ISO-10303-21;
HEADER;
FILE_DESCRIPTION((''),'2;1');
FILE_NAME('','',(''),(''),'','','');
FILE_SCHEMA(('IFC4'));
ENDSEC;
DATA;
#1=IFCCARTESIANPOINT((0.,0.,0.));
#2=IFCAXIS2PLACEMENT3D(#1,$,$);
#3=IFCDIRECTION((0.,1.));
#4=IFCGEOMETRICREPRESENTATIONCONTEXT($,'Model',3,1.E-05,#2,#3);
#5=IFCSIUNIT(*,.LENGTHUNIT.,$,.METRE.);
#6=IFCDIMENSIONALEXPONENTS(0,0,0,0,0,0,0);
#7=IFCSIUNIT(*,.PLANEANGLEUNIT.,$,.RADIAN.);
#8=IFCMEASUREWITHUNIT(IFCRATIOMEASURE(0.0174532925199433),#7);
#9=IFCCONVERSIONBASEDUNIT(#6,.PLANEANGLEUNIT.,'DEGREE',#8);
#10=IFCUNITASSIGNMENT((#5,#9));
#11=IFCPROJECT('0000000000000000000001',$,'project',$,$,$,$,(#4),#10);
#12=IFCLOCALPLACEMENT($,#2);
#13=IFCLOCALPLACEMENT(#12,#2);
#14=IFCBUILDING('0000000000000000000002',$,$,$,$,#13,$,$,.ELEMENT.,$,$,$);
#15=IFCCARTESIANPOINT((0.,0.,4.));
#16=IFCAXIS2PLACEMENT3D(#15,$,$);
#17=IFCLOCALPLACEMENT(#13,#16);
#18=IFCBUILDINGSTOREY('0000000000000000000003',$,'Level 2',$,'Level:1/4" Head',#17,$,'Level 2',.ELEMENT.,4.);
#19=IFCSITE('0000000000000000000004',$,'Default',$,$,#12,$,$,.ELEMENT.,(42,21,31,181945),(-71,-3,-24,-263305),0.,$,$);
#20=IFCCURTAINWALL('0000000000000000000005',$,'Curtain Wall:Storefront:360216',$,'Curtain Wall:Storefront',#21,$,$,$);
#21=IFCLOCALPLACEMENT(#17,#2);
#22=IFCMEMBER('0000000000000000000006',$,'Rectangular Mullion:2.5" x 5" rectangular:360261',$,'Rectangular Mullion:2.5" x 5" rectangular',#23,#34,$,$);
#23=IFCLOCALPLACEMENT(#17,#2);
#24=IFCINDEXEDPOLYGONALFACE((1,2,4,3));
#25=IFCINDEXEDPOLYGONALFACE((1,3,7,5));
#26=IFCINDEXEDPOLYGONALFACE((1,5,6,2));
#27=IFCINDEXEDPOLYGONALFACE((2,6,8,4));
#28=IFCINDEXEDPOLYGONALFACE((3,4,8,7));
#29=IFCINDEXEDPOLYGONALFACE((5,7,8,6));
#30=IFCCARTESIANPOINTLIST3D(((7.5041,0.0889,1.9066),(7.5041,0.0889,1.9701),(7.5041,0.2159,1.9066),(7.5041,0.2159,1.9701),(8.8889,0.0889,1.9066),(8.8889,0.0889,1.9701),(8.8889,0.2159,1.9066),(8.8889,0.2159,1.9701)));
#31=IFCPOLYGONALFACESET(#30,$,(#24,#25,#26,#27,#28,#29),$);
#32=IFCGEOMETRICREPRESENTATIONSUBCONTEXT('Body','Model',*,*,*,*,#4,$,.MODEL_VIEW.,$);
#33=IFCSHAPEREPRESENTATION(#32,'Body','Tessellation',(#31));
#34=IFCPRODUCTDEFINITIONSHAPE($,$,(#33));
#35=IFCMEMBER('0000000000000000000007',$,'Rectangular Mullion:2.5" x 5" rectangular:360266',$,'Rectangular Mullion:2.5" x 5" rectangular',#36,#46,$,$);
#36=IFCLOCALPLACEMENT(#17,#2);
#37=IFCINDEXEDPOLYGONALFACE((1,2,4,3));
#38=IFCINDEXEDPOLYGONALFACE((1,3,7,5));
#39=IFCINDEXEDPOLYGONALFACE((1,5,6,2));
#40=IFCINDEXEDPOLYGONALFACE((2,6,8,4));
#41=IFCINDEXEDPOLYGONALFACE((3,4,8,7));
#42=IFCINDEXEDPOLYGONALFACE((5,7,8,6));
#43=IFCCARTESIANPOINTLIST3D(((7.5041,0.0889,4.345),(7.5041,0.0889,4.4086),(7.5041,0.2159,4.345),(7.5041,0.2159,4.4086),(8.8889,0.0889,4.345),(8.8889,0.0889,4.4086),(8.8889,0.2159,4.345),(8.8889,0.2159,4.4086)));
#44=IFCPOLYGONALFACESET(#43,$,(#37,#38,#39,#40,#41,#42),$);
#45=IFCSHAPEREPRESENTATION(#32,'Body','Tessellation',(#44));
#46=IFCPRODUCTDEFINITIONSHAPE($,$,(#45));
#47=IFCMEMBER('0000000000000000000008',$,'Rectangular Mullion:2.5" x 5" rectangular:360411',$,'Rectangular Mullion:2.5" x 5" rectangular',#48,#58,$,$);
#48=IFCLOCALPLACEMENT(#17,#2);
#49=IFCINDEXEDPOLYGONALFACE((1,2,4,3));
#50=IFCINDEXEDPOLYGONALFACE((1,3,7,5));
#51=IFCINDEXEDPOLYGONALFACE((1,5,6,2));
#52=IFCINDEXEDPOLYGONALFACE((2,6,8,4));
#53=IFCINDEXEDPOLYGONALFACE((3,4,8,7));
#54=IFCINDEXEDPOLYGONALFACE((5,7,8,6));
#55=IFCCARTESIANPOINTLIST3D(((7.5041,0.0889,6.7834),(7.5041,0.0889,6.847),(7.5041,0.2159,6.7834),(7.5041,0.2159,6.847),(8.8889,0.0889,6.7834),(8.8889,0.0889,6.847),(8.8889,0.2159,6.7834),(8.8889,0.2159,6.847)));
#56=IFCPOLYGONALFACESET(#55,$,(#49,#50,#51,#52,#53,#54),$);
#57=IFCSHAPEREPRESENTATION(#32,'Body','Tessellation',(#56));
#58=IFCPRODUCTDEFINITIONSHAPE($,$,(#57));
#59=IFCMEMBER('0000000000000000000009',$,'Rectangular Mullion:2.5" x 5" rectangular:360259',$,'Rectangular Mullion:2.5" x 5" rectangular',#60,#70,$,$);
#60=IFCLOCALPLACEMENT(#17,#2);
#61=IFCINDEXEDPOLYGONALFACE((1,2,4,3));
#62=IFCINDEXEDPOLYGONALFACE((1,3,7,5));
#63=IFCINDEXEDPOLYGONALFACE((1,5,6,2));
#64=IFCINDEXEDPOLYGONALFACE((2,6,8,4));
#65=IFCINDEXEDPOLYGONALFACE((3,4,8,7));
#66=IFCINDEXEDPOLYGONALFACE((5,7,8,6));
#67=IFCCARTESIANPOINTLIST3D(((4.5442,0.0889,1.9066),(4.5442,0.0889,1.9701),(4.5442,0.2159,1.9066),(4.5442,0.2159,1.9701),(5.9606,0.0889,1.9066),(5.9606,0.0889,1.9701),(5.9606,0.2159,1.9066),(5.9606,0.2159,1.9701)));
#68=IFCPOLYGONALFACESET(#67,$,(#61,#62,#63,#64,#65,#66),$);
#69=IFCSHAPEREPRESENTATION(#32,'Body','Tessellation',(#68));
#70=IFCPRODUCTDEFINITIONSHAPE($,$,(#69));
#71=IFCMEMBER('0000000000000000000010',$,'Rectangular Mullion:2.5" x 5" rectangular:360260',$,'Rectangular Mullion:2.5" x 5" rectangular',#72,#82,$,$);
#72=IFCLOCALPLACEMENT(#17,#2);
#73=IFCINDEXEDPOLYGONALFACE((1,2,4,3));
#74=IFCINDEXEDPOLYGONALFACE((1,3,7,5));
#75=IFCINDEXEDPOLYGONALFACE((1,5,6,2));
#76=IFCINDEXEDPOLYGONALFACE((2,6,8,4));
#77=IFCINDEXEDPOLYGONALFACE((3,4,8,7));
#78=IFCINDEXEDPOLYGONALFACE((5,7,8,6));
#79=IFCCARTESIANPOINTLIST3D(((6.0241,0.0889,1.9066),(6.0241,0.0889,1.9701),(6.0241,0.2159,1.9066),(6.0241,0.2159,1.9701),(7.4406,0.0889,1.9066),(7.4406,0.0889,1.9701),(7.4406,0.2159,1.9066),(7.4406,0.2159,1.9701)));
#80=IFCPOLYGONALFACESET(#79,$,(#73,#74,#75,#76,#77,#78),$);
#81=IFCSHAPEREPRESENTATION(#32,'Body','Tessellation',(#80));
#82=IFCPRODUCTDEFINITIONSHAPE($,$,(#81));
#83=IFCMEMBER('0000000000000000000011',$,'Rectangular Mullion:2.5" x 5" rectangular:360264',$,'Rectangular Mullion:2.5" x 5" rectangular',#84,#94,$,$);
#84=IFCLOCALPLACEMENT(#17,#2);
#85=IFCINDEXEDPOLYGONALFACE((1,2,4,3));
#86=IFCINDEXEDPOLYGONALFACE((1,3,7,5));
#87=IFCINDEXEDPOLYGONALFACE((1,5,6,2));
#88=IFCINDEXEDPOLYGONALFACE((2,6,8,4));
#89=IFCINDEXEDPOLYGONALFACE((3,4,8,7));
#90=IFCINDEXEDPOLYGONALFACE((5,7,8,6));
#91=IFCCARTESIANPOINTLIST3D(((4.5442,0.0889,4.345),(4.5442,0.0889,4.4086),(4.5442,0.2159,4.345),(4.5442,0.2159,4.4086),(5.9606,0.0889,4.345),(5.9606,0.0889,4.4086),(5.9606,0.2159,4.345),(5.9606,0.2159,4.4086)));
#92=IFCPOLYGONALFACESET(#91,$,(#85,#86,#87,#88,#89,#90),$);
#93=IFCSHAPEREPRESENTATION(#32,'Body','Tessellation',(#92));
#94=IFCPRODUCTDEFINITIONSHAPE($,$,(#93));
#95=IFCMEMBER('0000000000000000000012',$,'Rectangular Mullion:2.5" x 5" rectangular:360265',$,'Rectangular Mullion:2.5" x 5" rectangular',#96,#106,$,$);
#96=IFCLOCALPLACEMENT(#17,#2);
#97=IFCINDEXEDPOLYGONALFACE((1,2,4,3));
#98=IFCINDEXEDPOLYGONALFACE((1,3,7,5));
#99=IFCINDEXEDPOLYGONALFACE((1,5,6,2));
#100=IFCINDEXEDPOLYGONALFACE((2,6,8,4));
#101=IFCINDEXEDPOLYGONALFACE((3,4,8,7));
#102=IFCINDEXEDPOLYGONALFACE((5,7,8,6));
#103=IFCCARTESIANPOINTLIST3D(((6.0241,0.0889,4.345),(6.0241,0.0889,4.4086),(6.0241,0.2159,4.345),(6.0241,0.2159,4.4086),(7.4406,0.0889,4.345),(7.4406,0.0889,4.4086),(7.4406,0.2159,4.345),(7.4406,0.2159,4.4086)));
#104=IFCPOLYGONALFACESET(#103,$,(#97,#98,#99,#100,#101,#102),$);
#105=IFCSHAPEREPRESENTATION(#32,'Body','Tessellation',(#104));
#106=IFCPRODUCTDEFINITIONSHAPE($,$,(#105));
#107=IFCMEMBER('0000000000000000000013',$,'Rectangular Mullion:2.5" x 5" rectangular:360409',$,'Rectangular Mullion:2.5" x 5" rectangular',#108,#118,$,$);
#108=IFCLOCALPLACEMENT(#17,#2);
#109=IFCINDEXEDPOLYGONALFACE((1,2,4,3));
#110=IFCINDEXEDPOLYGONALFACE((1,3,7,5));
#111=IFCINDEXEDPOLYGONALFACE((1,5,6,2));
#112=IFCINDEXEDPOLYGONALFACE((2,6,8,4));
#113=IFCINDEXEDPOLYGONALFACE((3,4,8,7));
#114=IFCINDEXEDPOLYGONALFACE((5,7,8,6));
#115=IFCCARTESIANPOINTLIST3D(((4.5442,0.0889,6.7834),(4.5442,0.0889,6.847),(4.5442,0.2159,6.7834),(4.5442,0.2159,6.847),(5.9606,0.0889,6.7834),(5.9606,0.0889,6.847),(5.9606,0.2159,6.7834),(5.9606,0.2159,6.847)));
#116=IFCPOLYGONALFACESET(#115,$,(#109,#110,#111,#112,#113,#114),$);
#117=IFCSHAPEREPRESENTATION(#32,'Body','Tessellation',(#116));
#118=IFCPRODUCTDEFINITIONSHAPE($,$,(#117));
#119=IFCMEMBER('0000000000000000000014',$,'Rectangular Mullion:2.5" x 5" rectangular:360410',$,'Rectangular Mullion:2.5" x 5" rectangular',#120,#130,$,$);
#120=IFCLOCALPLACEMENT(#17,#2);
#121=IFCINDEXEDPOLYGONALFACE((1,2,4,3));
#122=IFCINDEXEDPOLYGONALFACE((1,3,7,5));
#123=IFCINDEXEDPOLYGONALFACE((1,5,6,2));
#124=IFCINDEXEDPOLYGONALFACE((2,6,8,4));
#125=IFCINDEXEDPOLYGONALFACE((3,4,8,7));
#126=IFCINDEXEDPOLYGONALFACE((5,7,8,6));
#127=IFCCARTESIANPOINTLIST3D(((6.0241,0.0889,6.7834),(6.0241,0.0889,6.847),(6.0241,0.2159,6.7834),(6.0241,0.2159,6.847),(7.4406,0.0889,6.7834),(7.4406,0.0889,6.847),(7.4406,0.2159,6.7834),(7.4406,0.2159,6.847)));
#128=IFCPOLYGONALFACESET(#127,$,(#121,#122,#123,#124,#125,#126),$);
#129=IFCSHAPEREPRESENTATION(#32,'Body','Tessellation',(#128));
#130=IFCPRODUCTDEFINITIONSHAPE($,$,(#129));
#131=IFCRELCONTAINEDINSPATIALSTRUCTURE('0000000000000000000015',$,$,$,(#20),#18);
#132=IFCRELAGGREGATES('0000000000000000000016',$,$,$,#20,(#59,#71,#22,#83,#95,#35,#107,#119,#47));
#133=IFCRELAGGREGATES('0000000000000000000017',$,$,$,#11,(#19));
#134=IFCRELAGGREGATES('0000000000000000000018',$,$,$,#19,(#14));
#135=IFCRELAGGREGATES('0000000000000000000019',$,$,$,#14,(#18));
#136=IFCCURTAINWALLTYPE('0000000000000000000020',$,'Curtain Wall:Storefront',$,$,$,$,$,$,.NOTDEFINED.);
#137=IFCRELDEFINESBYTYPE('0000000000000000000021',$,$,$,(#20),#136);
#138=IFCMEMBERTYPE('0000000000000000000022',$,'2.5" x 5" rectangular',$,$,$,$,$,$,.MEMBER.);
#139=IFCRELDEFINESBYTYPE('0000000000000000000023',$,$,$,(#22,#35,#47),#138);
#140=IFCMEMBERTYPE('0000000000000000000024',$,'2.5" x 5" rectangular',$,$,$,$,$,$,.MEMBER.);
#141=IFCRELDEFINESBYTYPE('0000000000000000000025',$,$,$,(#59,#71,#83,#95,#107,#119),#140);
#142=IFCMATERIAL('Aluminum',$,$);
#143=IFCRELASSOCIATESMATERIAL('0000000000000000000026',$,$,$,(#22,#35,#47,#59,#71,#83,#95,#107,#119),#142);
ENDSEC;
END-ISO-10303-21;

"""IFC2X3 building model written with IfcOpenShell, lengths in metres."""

from ifc_helpers import new_model, entity, si_unit, converted_unit, direction, frame, origin, origin_2d_with_axis, place, context, subcontext, project, spatial, rectangle, extrude, source, transform, mapped, material, type_object, type_shapes, element, aggregate, save


model = new_model("IFC2X3")

# Units and contexts
model_context = context("Model", 3, precision=1e-05, world=origin(), true_north=direction((0.0, 1.0)))
body_context = subcontext(model_context, "Body", "Model", "MODEL_VIEW")
ifc_project = project(units=[si_unit("LENGTHUNIT", "METRE"), converted_unit("PLANEANGLEUNIT", "DEGREE", entity("IfcRatioMeasure", 0.0174532925199433), si_unit("PLANEANGLEUNIT", "RADIAN"), dimensions=[0, 0, 0, 0, 0, 0, 0])], contexts=[model_context])

# Site, building, storey
site_placement = place(None, origin())
site = spatial("IfcSite", under=ifc_project, at=site_placement, Name="Default", CompositionType="ELEMENT", RefLatitude=(42, 21, 31, 181945), RefLongitude=(-71, -3, -24, -263305), RefElevation=0.0)
building_placement = place(site_placement, origin())
building = spatial("IfcBuilding", under=site, at=building_placement, CompositionType="ELEMENT")
storey_placement = place(building_placement, frame((0.0, 0.0, 4.0)))
storey = spatial("IfcBuildingStorey", under=building, at=storey_placement, Name="Level 2", ObjectType="Level:1/4\" Head", LongName="Level 2", CompositionType="ELEMENT", Elevation=4.0)

# Curtain wall, members
curtain_wall_type = type_object("IfcCurtainWallType", Name="Curtain Wall:Storefront", PredefinedType="NOTDEFINED")
curtain_wall_placement = place(storey_placement, frame((0.0, 0.0, -4.0)))
curtain_wall = element("IfcCurtainWall", 1, at=curtain_wall_placement, inside=storey, type_object=curtain_wall_type, Name="Curtain Wall:Storefront:360216", ObjectType="Curtain Wall:Storefront")
ifc_material_1 = material(Name="Aluminum")
member_type_1 = type_object("IfcMemberType", Name="2.5\" x 5\" rectangular", PredefinedType="MEMBER")
shared_shape_1 = source(origin(), body_context, "Body", "SweptSolid", [
    extrude(rectangle(XDim=0.127, YDim=0.0635, at=origin_2d_with_axis()), frame((0.0, 0.0, -1.3848), z_axis=(0.0, 0.0, 1.0), x_axis=(0.0, -1.0, 0.0)), (0.0, 0.0, 1.0), 1.3848),
])
type_shapes(member_type_1, [shared_shape_1])
member_1_placement = place(storey_placement, frame((8.8889, 0.1524, 1.9384), z_axis=(1.0, 0.0, 0.0), x_axis=(0.0, 0.0, 1.0)))
member_1 = element("IfcMember", 2, at=member_1_placement, type_object=member_type_1, material=ifc_material_1, Name="Rectangular Mullion:2.5\" x 5\" rectangular:360261", ObjectType="Rectangular Mullion:2.5\" x 5\" rectangular", context=body_context, shape_type="MappedRepresentation", body=[
    mapped(shared_shape_1, transform((0.0, 0.0, 0.0), scale=1.0)),
])
member_2_placement = place(storey_placement, frame((8.8889, 0.1524, 4.3768), z_axis=(1.0, 0.0, 0.0), x_axis=(0.0, 0.0, 1.0)))
member_2 = element("IfcMember", 3, at=member_2_placement, type_object=member_type_1, material=ifc_material_1, Name="Rectangular Mullion:2.5\" x 5\" rectangular:360266", ObjectType="Rectangular Mullion:2.5\" x 5\" rectangular", context=body_context, shape_type="MappedRepresentation", body=[
    mapped(shared_shape_1, transform((0.0, 0.0, 0.0), scale=1.0)),
])
member_3_placement = place(storey_placement, frame((8.8889, 0.1524, 6.8152), z_axis=(1.0, 0.0, 0.0), x_axis=(0.0, 0.0, 1.0)))
member_3 = element("IfcMember", 4, at=member_3_placement, type_object=member_type_1, material=ifc_material_1, Name="Rectangular Mullion:2.5\" x 5\" rectangular:360411", ObjectType="Rectangular Mullion:2.5\" x 5\" rectangular", context=body_context, shape_type="MappedRepresentation", body=[
    mapped(shared_shape_1, transform((0.0, 0.0, 0.0), scale=1.0)),
])
member_type_2 = type_object("IfcMemberType", Name="2.5\" x 5\" rectangular", PredefinedType="MEMBER")
shared_shape_2 = source(origin(), body_context, "Body", "SweptSolid", [
    extrude(rectangle(XDim=0.127, YDim=0.0635, at=origin_2d_with_axis()), frame((0.0, 0.0, -1.4165), z_axis=(0.0, 0.0, 1.0), x_axis=(0.0, -1.0, 0.0)), (0.0, 0.0, 1.0), 1.4165),
])
type_shapes(member_type_2, [shared_shape_2])
member_4_placement = place(storey_placement, frame((5.9606, 0.1524, 1.9384), z_axis=(1.0, 0.0, 0.0), x_axis=(0.0, 0.0, 1.0)))
member_4 = element("IfcMember", 5, at=member_4_placement, type_object=member_type_2, material=ifc_material_1, Name="Rectangular Mullion:2.5\" x 5\" rectangular:360259", ObjectType="Rectangular Mullion:2.5\" x 5\" rectangular", context=body_context, shape_type="MappedRepresentation", body=[
    mapped(shared_shape_2, transform((0.0, 0.0, 0.0), scale=1.0)),
])
member_5_placement = place(storey_placement, frame((7.4406, 0.1524, 1.9384), z_axis=(1.0, 0.0, 0.0), x_axis=(0.0, 0.0, 1.0)))
member_5 = element("IfcMember", 6, at=member_5_placement, type_object=member_type_2, material=ifc_material_1, Name="Rectangular Mullion:2.5\" x 5\" rectangular:360260", ObjectType="Rectangular Mullion:2.5\" x 5\" rectangular", context=body_context, shape_type="MappedRepresentation", body=[
    mapped(shared_shape_2, transform((0.0, 0.0, 0.0), scale=1.0)),
])
member_6_placement = place(storey_placement, frame((5.9606, 0.1524, 4.3768), z_axis=(1.0, 0.0, 0.0), x_axis=(0.0, 0.0, 1.0)))
member_6 = element("IfcMember", 7, at=member_6_placement, type_object=member_type_2, material=ifc_material_1, Name="Rectangular Mullion:2.5\" x 5\" rectangular:360264", ObjectType="Rectangular Mullion:2.5\" x 5\" rectangular", context=body_context, shape_type="MappedRepresentation", body=[
    mapped(shared_shape_2, transform((0.0, 0.0, 0.0), scale=1.0)),
])
member_7_placement = place(storey_placement, frame((7.4406, 0.1524, 4.3768), z_axis=(1.0, 0.0, 0.0), x_axis=(0.0, 0.0, 1.0)))
member_7 = element("IfcMember", 8, at=member_7_placement, type_object=member_type_2, material=ifc_material_1, Name="Rectangular Mullion:2.5\" x 5\" rectangular:360265", ObjectType="Rectangular Mullion:2.5\" x 5\" rectangular", context=body_context, shape_type="MappedRepresentation", body=[
    mapped(shared_shape_2, transform((0.0, 0.0, 0.0), scale=1.0)),
])
member_8_placement = place(storey_placement, frame((5.9606, 0.1524, 6.8152), z_axis=(1.0, 0.0, 0.0), x_axis=(0.0, 0.0, 1.0)))
member_8 = element("IfcMember", 9, at=member_8_placement, type_object=member_type_2, material=ifc_material_1, Name="Rectangular Mullion:2.5\" x 5\" rectangular:360409", ObjectType="Rectangular Mullion:2.5\" x 5\" rectangular", context=body_context, shape_type="MappedRepresentation", body=[
    mapped(shared_shape_2, transform((0.0, 0.0, 0.0), scale=1.0)),
])
member_9_placement = place(storey_placement, frame((7.4406, 0.1524, 6.8152), z_axis=(1.0, 0.0, 0.0), x_axis=(0.0, 0.0, 1.0)))
member_9 = element("IfcMember", 10, at=member_9_placement, type_object=member_type_2, material=ifc_material_1, Name="Rectangular Mullion:2.5\" x 5\" rectangular:360410", ObjectType="Rectangular Mullion:2.5\" x 5\" rectangular", context=body_context, shape_type="MappedRepresentation", body=[
    mapped(shared_shape_2, transform((0.0, 0.0, 0.0), scale=1.0)),
])
aggregate(curtain_wall, [member_4, member_5, member_1, member_6, member_7, member_2, member_8, member_9, member_3])

save(model, "model.ifc")
